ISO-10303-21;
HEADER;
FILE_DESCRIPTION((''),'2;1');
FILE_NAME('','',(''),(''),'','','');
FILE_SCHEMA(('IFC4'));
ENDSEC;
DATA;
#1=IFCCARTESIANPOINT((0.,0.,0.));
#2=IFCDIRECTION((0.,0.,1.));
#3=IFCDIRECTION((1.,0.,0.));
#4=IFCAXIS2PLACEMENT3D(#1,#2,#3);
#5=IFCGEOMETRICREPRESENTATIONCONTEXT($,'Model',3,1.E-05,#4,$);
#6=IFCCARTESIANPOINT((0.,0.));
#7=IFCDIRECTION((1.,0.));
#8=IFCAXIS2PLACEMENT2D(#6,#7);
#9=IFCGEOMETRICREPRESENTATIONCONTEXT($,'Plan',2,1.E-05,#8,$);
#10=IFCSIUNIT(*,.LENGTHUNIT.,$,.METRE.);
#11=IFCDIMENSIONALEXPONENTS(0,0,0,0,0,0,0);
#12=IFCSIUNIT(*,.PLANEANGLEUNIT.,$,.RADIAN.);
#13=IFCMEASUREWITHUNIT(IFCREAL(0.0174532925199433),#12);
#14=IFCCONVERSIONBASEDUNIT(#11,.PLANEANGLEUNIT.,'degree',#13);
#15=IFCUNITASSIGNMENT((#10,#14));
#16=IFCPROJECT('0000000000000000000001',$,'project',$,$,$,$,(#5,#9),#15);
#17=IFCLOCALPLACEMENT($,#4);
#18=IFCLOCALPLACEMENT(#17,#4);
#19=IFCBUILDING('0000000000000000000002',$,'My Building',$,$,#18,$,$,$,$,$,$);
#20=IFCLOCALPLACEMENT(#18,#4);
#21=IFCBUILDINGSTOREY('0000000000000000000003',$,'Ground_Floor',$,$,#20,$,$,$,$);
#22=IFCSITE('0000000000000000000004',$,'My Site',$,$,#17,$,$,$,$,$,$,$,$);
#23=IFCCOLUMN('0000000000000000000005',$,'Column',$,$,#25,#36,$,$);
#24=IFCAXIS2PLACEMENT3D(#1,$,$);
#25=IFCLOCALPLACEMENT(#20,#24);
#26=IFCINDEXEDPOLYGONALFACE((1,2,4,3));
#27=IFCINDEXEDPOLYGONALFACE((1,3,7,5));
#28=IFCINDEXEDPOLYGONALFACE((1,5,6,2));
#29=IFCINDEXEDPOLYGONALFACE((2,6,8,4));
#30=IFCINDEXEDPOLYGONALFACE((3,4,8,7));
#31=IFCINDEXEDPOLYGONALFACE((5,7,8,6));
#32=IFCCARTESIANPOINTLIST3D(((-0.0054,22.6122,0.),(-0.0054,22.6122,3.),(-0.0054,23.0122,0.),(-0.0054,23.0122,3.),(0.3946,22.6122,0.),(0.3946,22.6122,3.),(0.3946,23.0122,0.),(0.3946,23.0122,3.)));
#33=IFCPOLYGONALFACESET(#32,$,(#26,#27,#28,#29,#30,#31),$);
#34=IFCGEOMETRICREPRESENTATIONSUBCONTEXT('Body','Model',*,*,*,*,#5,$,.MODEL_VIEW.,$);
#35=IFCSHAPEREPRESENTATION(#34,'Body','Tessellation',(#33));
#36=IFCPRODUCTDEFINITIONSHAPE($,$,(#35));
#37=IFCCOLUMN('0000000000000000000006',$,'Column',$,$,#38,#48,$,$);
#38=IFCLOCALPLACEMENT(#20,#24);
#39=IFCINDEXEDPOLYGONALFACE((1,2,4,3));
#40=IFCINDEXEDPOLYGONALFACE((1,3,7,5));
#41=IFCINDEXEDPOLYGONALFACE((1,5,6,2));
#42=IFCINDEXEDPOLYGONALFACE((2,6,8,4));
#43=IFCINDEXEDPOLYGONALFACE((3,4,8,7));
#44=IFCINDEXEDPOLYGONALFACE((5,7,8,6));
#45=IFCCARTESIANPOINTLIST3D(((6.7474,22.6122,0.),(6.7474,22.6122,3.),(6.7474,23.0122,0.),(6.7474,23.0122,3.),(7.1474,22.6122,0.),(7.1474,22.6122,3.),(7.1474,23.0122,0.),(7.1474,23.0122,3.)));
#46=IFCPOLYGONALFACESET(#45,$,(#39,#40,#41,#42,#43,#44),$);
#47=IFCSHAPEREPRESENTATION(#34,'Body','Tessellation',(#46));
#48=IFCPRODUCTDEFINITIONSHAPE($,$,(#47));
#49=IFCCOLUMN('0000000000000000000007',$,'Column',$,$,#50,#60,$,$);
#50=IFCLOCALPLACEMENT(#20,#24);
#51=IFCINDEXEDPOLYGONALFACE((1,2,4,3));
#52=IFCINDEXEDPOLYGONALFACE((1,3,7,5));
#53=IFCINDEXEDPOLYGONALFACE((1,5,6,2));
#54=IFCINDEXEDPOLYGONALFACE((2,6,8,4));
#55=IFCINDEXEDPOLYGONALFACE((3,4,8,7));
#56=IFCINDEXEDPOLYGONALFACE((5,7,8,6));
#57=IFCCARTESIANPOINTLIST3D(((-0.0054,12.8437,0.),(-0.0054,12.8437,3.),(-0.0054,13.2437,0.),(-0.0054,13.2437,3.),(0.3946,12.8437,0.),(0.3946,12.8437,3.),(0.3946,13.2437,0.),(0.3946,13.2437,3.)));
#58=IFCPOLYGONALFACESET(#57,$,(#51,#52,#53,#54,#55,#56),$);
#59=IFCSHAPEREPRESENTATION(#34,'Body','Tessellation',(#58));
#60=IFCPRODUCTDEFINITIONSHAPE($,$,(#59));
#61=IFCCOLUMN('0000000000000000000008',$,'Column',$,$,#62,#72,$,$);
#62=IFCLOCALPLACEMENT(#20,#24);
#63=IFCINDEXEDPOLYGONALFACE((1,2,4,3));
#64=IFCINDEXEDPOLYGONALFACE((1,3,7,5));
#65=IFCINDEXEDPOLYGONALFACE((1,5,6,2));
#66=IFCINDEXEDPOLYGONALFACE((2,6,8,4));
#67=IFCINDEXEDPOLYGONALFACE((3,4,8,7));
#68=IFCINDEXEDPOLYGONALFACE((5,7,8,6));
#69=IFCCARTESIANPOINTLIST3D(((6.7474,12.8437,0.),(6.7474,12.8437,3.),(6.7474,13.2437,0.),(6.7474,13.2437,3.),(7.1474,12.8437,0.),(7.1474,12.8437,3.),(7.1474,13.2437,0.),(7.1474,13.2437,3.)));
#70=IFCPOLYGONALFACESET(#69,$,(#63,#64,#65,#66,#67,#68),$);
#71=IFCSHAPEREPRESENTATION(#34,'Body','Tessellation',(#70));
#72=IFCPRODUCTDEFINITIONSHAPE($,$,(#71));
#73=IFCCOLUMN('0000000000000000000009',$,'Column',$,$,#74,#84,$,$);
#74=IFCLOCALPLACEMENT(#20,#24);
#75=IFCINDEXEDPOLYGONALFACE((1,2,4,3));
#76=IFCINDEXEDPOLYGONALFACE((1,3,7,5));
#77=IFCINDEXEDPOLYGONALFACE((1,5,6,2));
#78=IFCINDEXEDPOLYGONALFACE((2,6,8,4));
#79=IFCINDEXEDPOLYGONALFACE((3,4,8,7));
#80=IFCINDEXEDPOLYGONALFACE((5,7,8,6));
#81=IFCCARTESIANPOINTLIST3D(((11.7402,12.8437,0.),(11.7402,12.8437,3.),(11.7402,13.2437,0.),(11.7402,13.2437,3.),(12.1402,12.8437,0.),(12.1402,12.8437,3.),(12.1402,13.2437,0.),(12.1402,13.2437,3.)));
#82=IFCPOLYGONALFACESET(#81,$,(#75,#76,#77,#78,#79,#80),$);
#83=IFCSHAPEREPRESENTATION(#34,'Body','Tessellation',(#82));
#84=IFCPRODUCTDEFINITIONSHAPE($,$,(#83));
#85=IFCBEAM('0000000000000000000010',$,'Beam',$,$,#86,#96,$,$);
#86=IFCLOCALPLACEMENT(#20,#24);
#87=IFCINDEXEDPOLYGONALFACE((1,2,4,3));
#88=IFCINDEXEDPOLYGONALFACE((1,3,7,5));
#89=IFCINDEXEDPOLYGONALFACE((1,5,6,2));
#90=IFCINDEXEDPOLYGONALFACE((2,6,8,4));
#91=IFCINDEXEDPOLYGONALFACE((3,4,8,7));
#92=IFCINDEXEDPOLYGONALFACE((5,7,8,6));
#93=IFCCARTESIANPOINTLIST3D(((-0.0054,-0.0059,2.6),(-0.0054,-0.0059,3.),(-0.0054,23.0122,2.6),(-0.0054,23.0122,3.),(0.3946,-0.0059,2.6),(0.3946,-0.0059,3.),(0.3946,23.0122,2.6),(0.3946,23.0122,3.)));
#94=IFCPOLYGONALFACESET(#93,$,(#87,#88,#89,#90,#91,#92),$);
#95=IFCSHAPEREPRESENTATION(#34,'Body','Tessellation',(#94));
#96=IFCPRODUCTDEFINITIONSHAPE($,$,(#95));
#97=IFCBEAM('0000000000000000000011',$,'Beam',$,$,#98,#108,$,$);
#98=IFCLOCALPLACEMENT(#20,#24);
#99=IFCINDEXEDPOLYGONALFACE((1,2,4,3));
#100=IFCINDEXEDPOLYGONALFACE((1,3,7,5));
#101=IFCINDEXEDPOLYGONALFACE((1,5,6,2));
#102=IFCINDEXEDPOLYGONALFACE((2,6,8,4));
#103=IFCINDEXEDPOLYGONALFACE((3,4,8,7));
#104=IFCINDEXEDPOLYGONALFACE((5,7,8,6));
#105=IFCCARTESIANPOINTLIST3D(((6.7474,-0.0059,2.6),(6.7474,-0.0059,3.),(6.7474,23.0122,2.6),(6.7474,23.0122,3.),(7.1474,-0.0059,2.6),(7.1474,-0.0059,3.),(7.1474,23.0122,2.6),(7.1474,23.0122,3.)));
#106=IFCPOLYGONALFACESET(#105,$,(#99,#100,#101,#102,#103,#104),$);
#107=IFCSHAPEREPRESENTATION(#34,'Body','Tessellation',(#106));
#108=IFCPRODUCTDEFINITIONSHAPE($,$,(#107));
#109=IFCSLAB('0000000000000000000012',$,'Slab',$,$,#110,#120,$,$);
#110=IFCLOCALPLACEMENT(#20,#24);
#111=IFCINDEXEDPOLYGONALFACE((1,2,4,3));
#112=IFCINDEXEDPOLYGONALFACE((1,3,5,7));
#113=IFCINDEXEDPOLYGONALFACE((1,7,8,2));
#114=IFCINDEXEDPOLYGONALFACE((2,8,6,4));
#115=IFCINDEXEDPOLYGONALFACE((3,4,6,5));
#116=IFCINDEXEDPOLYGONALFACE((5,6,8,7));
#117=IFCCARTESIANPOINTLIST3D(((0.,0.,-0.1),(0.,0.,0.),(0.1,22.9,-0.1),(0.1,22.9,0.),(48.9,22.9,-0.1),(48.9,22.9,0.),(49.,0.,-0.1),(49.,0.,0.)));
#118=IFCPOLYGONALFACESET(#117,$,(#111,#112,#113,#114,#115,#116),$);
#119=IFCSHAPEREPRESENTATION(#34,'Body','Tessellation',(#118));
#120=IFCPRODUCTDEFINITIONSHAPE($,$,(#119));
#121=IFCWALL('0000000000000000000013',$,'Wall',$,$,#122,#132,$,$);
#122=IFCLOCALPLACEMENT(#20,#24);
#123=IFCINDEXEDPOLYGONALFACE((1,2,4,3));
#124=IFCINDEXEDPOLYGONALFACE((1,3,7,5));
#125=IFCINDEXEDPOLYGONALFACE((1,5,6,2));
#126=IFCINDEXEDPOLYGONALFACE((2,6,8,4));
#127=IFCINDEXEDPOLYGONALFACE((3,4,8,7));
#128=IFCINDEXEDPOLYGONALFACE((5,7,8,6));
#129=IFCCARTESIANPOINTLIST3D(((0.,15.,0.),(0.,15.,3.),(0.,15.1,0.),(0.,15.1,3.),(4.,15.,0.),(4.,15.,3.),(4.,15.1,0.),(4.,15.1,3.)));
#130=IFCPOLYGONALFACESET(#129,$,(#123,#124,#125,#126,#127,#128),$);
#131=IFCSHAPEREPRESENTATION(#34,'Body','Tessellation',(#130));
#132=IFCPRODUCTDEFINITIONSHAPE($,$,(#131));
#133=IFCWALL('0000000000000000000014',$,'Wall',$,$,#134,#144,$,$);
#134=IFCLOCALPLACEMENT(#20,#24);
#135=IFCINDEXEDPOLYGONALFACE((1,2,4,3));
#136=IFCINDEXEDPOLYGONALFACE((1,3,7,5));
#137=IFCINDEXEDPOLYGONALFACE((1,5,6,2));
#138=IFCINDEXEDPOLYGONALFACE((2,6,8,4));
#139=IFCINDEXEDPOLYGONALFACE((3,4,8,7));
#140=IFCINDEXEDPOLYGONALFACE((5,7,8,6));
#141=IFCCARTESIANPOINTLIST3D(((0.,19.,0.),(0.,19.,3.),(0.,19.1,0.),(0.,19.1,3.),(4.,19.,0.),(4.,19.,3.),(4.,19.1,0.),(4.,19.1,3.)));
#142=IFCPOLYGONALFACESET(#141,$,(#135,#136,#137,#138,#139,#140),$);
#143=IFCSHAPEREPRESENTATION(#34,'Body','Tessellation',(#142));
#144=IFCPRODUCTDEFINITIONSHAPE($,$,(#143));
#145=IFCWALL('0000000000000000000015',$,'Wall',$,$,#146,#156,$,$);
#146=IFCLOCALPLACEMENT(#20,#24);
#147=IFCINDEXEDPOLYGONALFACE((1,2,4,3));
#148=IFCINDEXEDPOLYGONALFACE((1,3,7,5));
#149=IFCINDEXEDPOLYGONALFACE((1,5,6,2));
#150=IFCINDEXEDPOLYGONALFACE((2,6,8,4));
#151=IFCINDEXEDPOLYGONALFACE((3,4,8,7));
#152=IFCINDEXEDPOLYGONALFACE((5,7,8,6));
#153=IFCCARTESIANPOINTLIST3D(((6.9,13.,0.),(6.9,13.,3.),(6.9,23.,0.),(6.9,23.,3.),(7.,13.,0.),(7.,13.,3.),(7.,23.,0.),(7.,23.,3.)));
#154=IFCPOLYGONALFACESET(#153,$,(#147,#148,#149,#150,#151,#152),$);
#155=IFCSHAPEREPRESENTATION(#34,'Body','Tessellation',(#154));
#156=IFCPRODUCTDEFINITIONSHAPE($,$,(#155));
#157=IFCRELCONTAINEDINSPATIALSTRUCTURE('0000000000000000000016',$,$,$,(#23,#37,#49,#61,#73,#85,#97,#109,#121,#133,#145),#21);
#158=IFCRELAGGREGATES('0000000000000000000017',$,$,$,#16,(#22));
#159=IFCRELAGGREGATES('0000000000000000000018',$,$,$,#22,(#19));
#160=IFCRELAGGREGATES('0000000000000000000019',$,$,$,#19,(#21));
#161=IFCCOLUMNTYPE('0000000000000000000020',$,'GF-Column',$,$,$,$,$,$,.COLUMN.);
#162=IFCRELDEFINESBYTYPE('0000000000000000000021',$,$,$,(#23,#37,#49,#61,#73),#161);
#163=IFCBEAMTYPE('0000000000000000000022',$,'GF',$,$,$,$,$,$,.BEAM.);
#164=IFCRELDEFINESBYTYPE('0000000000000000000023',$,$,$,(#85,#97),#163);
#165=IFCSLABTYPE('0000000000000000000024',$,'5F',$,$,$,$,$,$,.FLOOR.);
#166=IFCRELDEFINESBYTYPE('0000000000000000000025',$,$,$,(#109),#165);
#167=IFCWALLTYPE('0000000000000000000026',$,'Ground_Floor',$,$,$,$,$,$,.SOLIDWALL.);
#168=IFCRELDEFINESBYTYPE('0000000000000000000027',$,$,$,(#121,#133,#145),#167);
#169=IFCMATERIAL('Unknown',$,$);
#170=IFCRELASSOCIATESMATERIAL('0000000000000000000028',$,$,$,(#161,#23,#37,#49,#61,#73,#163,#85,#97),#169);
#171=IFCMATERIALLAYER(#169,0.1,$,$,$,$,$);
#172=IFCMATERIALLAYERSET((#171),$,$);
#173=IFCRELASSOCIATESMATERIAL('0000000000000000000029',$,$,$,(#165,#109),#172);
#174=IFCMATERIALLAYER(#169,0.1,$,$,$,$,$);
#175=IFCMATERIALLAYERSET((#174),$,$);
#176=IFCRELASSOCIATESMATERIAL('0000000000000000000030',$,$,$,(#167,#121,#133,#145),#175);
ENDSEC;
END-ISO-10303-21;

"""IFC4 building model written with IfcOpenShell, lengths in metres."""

from ifc_helpers import new_model, entity, si_unit, converted_unit, frame, origin_with_axes, origin_2d_with_axis, place, context, subcontext, project, spatial, line, indexed_curve, rectangle, outline, extrude, material, layer, layer_set, layer_usage, material_profile, profile_set, profile_usage, type_object, element, save


model = new_model("IFC4")

# Units and contexts
model_context = context("Model", 3, precision=1e-05, world=origin_with_axes())
plan_context = context("Plan", 2, precision=1e-05, world=origin_2d_with_axis())
body_context_1 = subcontext(model_context, "Body", "Model", "MODEL_VIEW")
ifc_project = project(units=[si_unit("LENGTHUNIT", "METRE"), converted_unit("PLANEANGLEUNIT", "degree", entity("IfcReal", 0.0174532925199433), si_unit("PLANEANGLEUNIT", "RADIAN"), dimensions=[0, 0, 0, 0, 0, 0, 0])], contexts=[model_context, plan_context])

# Site, building, storey
site_placement = place(None, origin_with_axes())
site = spatial("IfcSite", under=ifc_project, at=site_placement, Name="My Site")
building_placement = place(site_placement, origin_with_axes())
building = spatial("IfcBuilding", under=site, at=building_placement, Name="My Building")
storey_placement = place(building_placement, origin_with_axes())
storey = spatial("IfcBuildingStorey", under=building, at=storey_placement, Name="Ground_Floor")

# Columns
ifc_material = material(Name="Unknown")
ifc_material_profile_1 = material_profile(ifc_material, rectangle(XDim=0.4, YDim=0.4))
ifc_profile_set_1 = profile_set([ifc_material_profile_1])
ifc_profile_usage_1 = profile_usage(ifc_profile_set_1, cardinal=5)
column_type = type_object("IfcColumnType", Name="GF-Column", PredefinedType="COLUMN", material=ifc_profile_set_1)
column_1_placement = place(storey_placement, frame((0.1946, 22.8122, 0.0), z_axis=(0.0, 0.0, 1.0), x_axis=(1.0, 0.0, 0.0)))
element("IfcColumn", 1, at=column_1_placement, inside=storey, type_object=column_type, material=ifc_profile_usage_1, Name="Column", context=body_context_1, shape_type="SweptSolid", body=[
    extrude(rectangle(XDim=0.4, YDim=0.4), origin_with_axes(), (0.0, 0.0, 1.0), 3.0),
])
ifc_profile_usage_2 = profile_usage(ifc_profile_set_1, cardinal=5)
column_2_placement = place(storey_placement, frame((6.9474, 22.8122, 0.0), z_axis=(0.0, 0.0, 1.0), x_axis=(1.0, 0.0, 0.0)))
element("IfcColumn", 2, at=column_2_placement, inside=storey, type_object=column_type, material=ifc_profile_usage_2, Name="Column", context=body_context_1, shape_type="SweptSolid", body=[
    extrude(rectangle(XDim=0.4, YDim=0.4), origin_with_axes(), (0.0, 0.0, 1.0), 3.0),
])
ifc_profile_usage_3 = profile_usage(ifc_profile_set_1, cardinal=5)
column_3_placement = place(storey_placement, frame((0.1946, 13.0437, 0.0), z_axis=(0.0, 0.0, 1.0), x_axis=(1.0, 0.0, 0.0)))
element("IfcColumn", 3, at=column_3_placement, inside=storey, type_object=column_type, material=ifc_profile_usage_3, Name="Column", context=body_context_1, shape_type="SweptSolid", body=[
    extrude(rectangle(XDim=0.4, YDim=0.4), origin_with_axes(), (0.0, 0.0, 1.0), 3.0),
])
ifc_profile_usage_4 = profile_usage(ifc_profile_set_1, cardinal=5)
column_4_placement = place(storey_placement, frame((6.9474, 13.0437, 0.0), z_axis=(0.0, 0.0, 1.0), x_axis=(1.0, 0.0, 0.0)))
element("IfcColumn", 4, at=column_4_placement, inside=storey, type_object=column_type, material=ifc_profile_usage_4, Name="Column", context=body_context_1, shape_type="SweptSolid", body=[
    extrude(rectangle(XDim=0.4, YDim=0.4), origin_with_axes(), (0.0, 0.0, 1.0), 3.0),
])
ifc_profile_usage_5 = profile_usage(ifc_profile_set_1, cardinal=5)
column_5_placement = place(storey_placement, frame((11.9402, 13.0437, 0.0), z_axis=(0.0, 0.0, 1.0), x_axis=(1.0, 0.0, 0.0)))
element("IfcColumn", 5, at=column_5_placement, inside=storey, type_object=column_type, material=ifc_profile_usage_5, Name="Column", context=body_context_1, shape_type="SweptSolid", body=[
    extrude(rectangle(XDim=0.4, YDim=0.4), origin_with_axes(), (0.0, 0.0, 1.0), 3.0),
])

# Beams
ifc_material_profile_2 = material_profile(ifc_material, rectangle(XDim=0.4, YDim=0.4))
ifc_profile_set_2 = profile_set([ifc_material_profile_2])
ifc_profile_usage_6 = profile_usage(ifc_profile_set_2, cardinal=5)
beam_type = type_object("IfcBeamType", Name="GF", PredefinedType="BEAM", material=ifc_profile_set_2)
beam_1_placement = place(storey_placement, frame((0.1946, 23.0122, 2.8), z_axis=(0.0, -1.0, 0.0), x_axis=(1.0, 0.0, 0.0)))
element("IfcBeam", 6, at=beam_1_placement, inside=storey, type_object=beam_type, material=ifc_profile_usage_6, Name="Beam", context=body_context_1, shape_type="SweptSolid", body=[
    extrude(rectangle(XDim=0.4, YDim=0.4), origin_with_axes(), (0.0, 0.0, 1.0), 23.0181),
])
ifc_profile_usage_7 = profile_usage(ifc_profile_set_2, cardinal=5)
beam_2_placement = place(storey_placement, frame((6.9474, 23.0122, 2.8), z_axis=(0.0, -1.0, 0.0), x_axis=(1.0, 0.0, 0.0)))
element("IfcBeam", 7, at=beam_2_placement, inside=storey, type_object=beam_type, material=ifc_profile_usage_7, Name="Beam", context=body_context_1, shape_type="SweptSolid", body=[
    extrude(rectangle(XDim=0.4, YDim=0.4), origin_with_axes(), (0.0, 0.0, 1.0), 23.0181),
])

# Slab
ifc_layer_1 = layer(ifc_material, 0.1)
ifc_layer_set_1 = layer_set([ifc_layer_1])
ifc_layer_usage_1 = layer_usage(ifc_layer_set_1, "AXIS3", "POSITIVE", -0.1)
slab_type = type_object("IfcSlabType", Name="5F", PredefinedType="FLOOR", material=ifc_layer_set_1)
slab_placement = place(storey_placement, frame((0.1, 22.9, 0.0), z_axis=(0.0, 0.0, 1.0), x_axis=(1.0, 0.0, 0.0)))
element("IfcSlab", 8, at=slab_placement, inside=storey, type_object=slab_type, material=ifc_layer_usage_1, Name="Slab", context=body_context_1, shape_type="SweptSolid", body=[
    extrude(outline(indexed_curve([(0.0, 0.0), (48.8, 0.0), (48.9, -22.9), (-0.1, -22.9), (0.0, 0.0)])), frame((0.0, 0.0, -0.1), z_axis=(0.0, 0.0, 1.0), x_axis=(1.0, 0.0, 0.0)), (0.0, 0.0, 1.0), 0.1),
])

# Shared definitions
ifc_layer_2 = layer(ifc_material, 0.1)
ifc_layer_set_2 = layer_set([ifc_layer_2])
wall_type = type_object("IfcWallType", Name="Ground_Floor", PredefinedType="SOLIDWALL", material=ifc_layer_set_2)

# Walls
ifc_layer_usage_2 = layer_usage(ifc_layer_set_2, "AXIS2", "POSITIVE", 0.0)
wall_1_placement = place(storey_placement, frame((0.0, 15.0, 0.0), z_axis=(0.0, 0.0, 1.0), x_axis=(1.0, 0.0, 0.0)))
element("IfcWall", 9, at=wall_1_placement, inside=storey, type_object=wall_type, material=ifc_layer_usage_2, Name="Wall", context=body_context_1, shape_type="SweptSolid", body=[
    extrude(outline(indexed_curve([(0.0, 0.0), (0.0, 0.1), (4.0, 0.1), (4.0, 0.0)], segments=[line(1, 2, 3, 4, 1)])), origin_with_axes(), (0.0, 0.0, 1.0), 3.0),
])
ifc_layer_usage_3 = layer_usage(ifc_layer_set_2, "AXIS2", "POSITIVE", 0.0)
wall_2_placement = place(storey_placement, frame((0.0, 19.0, 0.0), z_axis=(0.0, 0.0, 1.0), x_axis=(1.0, 0.0, 0.0)))
element("IfcWall", 10, at=wall_2_placement, inside=storey, type_object=wall_type, material=ifc_layer_usage_3, Name="Wall", context=body_context_1, shape_type="SweptSolid", body=[
    extrude(outline(indexed_curve([(0.0, 0.0), (0.0, 0.1), (4.0, 0.1), (4.0, 0.0)], segments=[line(1, 2, 3, 4, 1)])), origin_with_axes(), (0.0, 0.0, 1.0), 3.0),
])
ifc_layer_usage_4 = layer_usage(ifc_layer_set_2, "AXIS2", "POSITIVE", 0.0)
wall_3_placement = place(storey_placement, frame((7.0, 13.0, 0.0), z_axis=(0.0, 0.0, 1.0), x_axis=(0.0, 1.0, 0.0)))
element("IfcWall", 11, at=wall_3_placement, inside=storey, type_object=wall_type, material=ifc_layer_usage_4, Name="Wall", context=body_context_1, shape_type="SweptSolid", body=[
    extrude(outline(indexed_curve([(0.0, 0.0), (0.0, 0.1), (10.0, 0.1), (10.0, 0.0)], segments=[line(1, 2, 3, 4, 1)])), origin_with_axes(), (0.0, 0.0, 1.0), 3.0),
])

save(model, "model.ifc")
